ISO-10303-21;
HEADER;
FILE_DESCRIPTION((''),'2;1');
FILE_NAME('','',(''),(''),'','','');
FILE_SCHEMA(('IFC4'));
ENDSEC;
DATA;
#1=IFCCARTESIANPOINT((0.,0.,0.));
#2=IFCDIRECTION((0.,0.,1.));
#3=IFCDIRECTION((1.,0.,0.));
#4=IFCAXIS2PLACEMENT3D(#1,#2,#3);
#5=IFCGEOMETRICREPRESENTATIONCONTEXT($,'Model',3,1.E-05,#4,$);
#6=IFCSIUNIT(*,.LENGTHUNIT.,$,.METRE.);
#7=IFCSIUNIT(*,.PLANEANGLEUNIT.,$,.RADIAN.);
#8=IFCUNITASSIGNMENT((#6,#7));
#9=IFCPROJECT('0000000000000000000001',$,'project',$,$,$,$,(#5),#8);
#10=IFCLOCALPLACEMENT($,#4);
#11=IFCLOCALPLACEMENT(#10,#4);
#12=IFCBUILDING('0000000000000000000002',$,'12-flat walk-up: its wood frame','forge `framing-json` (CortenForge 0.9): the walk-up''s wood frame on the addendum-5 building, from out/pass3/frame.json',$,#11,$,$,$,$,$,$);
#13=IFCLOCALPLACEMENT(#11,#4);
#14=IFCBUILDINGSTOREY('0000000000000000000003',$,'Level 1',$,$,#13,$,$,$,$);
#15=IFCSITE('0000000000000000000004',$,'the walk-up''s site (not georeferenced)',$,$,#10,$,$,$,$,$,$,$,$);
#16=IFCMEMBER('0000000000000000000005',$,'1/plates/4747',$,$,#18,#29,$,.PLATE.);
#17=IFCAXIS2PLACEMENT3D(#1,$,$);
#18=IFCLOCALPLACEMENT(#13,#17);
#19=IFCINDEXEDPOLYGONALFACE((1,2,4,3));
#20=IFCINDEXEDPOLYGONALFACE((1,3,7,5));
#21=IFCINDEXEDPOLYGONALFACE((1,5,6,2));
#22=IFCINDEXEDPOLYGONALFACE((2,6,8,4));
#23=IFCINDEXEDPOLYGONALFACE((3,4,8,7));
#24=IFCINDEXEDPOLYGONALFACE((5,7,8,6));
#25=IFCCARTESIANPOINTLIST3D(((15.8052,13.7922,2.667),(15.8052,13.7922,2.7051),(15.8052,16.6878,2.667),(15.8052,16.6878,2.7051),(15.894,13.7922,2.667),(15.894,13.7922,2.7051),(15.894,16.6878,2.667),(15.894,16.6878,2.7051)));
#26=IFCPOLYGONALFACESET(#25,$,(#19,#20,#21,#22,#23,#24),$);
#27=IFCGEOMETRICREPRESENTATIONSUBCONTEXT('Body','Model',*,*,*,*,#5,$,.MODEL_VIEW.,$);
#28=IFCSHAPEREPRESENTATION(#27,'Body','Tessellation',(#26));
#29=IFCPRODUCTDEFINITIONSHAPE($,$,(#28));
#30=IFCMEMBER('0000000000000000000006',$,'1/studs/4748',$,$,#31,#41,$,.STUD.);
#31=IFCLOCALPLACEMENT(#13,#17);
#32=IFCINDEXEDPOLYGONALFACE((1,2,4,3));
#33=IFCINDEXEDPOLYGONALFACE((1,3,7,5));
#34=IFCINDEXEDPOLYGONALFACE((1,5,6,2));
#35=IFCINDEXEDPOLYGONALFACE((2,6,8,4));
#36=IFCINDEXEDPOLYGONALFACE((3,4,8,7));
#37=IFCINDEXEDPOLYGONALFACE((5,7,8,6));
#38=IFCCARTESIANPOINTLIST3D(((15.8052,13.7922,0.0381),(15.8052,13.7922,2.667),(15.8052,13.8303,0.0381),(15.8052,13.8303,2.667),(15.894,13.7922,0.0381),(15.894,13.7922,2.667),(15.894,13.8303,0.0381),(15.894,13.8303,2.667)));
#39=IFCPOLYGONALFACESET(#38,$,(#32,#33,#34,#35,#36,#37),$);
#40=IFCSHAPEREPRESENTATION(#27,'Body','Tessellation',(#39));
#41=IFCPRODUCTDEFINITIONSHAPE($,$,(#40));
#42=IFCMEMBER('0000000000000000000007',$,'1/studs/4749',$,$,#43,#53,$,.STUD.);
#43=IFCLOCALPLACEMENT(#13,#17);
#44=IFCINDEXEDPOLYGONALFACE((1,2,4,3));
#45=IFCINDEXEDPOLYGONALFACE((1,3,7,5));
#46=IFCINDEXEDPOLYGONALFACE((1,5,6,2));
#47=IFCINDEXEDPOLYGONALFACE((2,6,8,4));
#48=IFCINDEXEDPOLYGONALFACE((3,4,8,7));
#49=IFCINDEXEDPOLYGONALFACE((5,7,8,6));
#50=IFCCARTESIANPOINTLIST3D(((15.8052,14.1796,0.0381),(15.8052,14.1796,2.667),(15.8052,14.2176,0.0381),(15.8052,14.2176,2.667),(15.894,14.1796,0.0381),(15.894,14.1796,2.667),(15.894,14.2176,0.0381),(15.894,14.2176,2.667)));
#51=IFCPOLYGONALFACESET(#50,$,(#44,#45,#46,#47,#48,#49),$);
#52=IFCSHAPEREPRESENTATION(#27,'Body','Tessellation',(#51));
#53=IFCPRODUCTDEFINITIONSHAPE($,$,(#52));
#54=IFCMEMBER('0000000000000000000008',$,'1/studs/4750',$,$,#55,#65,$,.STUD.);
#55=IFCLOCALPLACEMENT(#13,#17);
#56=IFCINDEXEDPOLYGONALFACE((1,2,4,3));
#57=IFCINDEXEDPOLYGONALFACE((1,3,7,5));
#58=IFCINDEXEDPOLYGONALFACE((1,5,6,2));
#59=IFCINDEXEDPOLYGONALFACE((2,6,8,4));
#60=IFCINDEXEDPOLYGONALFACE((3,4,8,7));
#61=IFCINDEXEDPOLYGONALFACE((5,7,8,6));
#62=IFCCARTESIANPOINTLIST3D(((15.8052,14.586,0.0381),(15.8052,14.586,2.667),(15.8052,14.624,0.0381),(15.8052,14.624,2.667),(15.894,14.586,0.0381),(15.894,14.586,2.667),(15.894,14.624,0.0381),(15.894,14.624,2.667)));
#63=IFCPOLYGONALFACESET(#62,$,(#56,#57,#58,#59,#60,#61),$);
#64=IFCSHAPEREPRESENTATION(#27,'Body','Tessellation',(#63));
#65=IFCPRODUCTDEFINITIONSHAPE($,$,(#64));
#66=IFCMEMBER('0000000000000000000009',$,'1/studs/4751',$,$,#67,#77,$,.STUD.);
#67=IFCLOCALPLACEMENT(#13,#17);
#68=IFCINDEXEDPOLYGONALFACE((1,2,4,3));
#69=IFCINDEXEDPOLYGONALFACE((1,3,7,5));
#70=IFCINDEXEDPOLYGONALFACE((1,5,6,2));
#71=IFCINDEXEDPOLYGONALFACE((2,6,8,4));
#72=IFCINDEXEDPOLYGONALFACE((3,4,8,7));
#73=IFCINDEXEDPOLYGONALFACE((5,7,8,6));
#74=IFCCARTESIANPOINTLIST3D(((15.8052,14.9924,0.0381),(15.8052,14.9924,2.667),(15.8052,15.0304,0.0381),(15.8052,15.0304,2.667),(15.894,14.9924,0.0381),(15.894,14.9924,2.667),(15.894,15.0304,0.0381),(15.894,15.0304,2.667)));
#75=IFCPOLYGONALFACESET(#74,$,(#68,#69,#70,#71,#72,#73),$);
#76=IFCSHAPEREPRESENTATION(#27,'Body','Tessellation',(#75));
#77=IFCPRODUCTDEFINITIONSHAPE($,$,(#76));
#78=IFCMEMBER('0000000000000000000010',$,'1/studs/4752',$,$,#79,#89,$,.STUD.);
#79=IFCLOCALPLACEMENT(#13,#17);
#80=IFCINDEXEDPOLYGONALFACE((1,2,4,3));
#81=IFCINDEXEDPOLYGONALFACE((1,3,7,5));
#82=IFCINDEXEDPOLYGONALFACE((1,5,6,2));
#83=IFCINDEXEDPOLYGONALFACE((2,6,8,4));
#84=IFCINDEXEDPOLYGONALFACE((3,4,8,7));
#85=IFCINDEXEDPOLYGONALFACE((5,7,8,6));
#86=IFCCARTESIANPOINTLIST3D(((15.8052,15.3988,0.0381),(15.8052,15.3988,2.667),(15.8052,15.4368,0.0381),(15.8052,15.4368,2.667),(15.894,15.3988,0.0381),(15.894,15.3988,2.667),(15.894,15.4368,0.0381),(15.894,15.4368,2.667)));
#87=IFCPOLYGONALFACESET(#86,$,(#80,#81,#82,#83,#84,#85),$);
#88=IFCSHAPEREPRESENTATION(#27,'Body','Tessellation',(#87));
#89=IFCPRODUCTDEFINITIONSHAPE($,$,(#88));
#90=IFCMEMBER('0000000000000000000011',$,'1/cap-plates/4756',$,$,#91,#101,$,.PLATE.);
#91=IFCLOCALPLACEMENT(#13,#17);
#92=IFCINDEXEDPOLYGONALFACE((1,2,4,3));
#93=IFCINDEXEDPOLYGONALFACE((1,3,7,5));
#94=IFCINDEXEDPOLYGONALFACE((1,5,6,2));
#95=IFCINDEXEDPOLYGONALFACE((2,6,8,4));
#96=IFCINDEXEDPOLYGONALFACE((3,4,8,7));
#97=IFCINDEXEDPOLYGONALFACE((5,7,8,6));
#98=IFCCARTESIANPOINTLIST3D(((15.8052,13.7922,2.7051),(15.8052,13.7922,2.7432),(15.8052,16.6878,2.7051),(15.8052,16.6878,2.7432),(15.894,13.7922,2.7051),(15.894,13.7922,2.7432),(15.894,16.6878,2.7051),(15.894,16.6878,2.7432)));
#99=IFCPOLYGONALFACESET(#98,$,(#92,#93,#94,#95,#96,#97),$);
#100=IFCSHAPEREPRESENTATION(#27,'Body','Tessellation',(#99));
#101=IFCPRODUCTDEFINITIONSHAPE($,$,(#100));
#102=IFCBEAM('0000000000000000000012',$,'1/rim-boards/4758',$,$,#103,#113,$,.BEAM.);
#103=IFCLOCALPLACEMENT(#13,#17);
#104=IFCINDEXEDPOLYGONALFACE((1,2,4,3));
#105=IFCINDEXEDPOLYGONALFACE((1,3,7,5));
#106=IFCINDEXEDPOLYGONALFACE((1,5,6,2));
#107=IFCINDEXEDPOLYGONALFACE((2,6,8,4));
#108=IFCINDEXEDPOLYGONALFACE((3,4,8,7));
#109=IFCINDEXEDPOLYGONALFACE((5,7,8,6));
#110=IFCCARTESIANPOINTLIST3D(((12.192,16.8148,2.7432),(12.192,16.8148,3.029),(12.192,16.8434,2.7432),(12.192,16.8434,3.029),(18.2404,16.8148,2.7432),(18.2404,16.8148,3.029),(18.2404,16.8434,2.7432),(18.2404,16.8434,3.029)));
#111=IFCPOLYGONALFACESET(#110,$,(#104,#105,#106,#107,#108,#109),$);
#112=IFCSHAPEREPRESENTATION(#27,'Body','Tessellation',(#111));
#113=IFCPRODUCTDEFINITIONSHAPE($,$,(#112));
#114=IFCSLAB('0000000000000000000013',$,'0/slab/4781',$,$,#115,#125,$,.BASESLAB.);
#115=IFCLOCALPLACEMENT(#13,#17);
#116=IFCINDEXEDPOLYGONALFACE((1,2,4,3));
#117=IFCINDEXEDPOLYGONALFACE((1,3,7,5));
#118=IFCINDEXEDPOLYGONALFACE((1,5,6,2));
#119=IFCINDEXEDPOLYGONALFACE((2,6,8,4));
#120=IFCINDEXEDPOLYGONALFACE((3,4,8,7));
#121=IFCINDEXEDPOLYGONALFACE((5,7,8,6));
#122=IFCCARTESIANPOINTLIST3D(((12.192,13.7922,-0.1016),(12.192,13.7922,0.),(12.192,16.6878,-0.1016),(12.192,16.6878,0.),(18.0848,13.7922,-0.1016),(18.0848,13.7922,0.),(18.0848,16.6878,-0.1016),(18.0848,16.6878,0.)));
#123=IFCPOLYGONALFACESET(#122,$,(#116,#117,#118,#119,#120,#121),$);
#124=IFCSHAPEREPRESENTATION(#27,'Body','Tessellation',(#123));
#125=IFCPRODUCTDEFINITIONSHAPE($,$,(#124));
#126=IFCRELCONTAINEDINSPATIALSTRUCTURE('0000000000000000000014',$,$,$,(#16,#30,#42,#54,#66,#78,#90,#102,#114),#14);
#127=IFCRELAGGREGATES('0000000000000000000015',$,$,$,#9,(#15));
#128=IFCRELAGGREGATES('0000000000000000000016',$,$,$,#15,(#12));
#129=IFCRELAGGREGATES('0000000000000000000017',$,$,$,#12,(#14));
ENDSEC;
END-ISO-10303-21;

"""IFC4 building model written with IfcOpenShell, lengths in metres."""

from ifc_helpers import new_model, si_unit, frame, frame_2d, origin, origin_with_axes, place, context, subcontext, project, spatial, rectangle, extrude, element, save


model = new_model("IFC4")

# Units and contexts
model_context = context("Model", 3, precision=1e-05, world=origin_with_axes())
body_context = subcontext(model_context, "Body", "Model", "MODEL_VIEW")
ifc_project = project(units=[si_unit("LENGTHUNIT", "METRE"), si_unit("PLANEANGLEUNIT", "RADIAN")], contexts=[model_context])

# Site, building, storey
site_placement = place(None, origin_with_axes())
site = spatial("IfcSite", under=ifc_project, at=site_placement, Name="the walk-up's site (not georeferenced)")
building_placement = place(site_placement, origin_with_axes())
building = spatial("IfcBuilding", under=site, at=building_placement, Name="12-flat walk-up: its wood frame", Description="forge `framing-json` (CortenForge 0.9): the walk-up's wood frame on the addendum-5 building, from out/pass3/frame.json")
storey_placement = place(building_placement, origin_with_axes())
storey = spatial("IfcBuildingStorey", under=building, at=storey_placement, Name="Level 1")

# Members
member_1_placement = place(storey_placement, frame((15.8051, 13.7922, 2.667), z_axis=(0.0, 0.0, 1.0), x_axis=(1.0, 0.0, 0.0)))
element("IfcMember", 1, at=member_1_placement, inside=storey, Name="1/plates/4747", PredefinedType="PLATE", context=body_context, shape_type="SweptSolid", body=[
    extrude(rectangle(XDim=0.0889, YDim=2.8956, at=frame_2d((0.0445, 1.4478))), origin(), (0.0, 0.0, 1.0), 0.0381),
])
for number, where, z_axis, x_axis, name in (
    (2, (15.8051, 13.7922, 0.0381), (0.0, 0.0, 1.0), (1.0, 0.0, 0.0), "1/studs/4748"),
    (3, (15.8051, 14.1796, 0.0381), (0.0, 0.0, 1.0), (1.0, 0.0, 0.0), "1/studs/4749"),
    (4, (15.8051, 14.586, 0.0381), (0.0, 0.0, 1.0), (1.0, 0.0, 0.0), "1/studs/4750"),
    (5, (15.8051, 14.9924, 0.0381), (0.0, 0.0, 1.0), (1.0, 0.0, 0.0), "1/studs/4751"),
    (6, (15.8051, 15.3987, 0.0381), (0.0, 0.0, 1.0), (1.0, 0.0, 0.0), "1/studs/4752"),
):
    element("IfcMember", number, at=place(storey_placement, frame(where, z_axis=z_axis, x_axis=x_axis)), inside=storey, Name=name, PredefinedType="STUD", context=body_context, shape_type="SweptSolid", body=[
        extrude(rectangle(XDim=0.0889, YDim=0.0381, at=frame_2d((0.0445, 0.0191))), origin(), (0.0, 0.0, 1.0), 2.6289),
    ])
member_2_placement = place(storey_placement, frame((15.8051, 13.7922, 2.7051), z_axis=(0.0, 0.0, 1.0), x_axis=(1.0, 0.0, 0.0)))
element("IfcMember", 7, at=member_2_placement, inside=storey, Name="1/cap-plates/4756", PredefinedType="PLATE", context=body_context, shape_type="SweptSolid", body=[
    extrude(rectangle(XDim=0.0889, YDim=2.8956, at=frame_2d((0.0445, 1.4478))), origin(), (0.0, 0.0, 1.0), 0.0381),
])

# Beam
beam_placement = place(storey_placement, frame((12.192, 16.8148, 2.7432), z_axis=(0.0, 0.0, 1.0), x_axis=(1.0, 0.0, 0.0)))
element("IfcBeam", 8, at=beam_placement, inside=storey, Name="1/rim-boards/4758", PredefinedType="BEAM", context=body_context, shape_type="SweptSolid", body=[
    extrude(rectangle(XDim=6.0484, YDim=0.0286, at=frame_2d((3.0242, 0.0143))), origin(), (0.0, 0.0, 1.0), 0.2858),
])

# Slab
slab_placement = place(storey_placement, frame((12.192, 13.7922, -0.1016), z_axis=(0.0, 0.0, 1.0), x_axis=(1.0, 0.0, 0.0)))
element("IfcSlab", 9, at=slab_placement, inside=storey, Name="0/slab/4781", PredefinedType="BASESLAB", context=body_context, shape_type="SweptSolid", body=[
    extrude(rectangle(XDim=5.8928, YDim=2.8956, at=frame_2d((2.9464, 1.4478))), origin(), (0.0, 0.0, 1.0), 0.1016),
])

save(model, "model.ifc")
